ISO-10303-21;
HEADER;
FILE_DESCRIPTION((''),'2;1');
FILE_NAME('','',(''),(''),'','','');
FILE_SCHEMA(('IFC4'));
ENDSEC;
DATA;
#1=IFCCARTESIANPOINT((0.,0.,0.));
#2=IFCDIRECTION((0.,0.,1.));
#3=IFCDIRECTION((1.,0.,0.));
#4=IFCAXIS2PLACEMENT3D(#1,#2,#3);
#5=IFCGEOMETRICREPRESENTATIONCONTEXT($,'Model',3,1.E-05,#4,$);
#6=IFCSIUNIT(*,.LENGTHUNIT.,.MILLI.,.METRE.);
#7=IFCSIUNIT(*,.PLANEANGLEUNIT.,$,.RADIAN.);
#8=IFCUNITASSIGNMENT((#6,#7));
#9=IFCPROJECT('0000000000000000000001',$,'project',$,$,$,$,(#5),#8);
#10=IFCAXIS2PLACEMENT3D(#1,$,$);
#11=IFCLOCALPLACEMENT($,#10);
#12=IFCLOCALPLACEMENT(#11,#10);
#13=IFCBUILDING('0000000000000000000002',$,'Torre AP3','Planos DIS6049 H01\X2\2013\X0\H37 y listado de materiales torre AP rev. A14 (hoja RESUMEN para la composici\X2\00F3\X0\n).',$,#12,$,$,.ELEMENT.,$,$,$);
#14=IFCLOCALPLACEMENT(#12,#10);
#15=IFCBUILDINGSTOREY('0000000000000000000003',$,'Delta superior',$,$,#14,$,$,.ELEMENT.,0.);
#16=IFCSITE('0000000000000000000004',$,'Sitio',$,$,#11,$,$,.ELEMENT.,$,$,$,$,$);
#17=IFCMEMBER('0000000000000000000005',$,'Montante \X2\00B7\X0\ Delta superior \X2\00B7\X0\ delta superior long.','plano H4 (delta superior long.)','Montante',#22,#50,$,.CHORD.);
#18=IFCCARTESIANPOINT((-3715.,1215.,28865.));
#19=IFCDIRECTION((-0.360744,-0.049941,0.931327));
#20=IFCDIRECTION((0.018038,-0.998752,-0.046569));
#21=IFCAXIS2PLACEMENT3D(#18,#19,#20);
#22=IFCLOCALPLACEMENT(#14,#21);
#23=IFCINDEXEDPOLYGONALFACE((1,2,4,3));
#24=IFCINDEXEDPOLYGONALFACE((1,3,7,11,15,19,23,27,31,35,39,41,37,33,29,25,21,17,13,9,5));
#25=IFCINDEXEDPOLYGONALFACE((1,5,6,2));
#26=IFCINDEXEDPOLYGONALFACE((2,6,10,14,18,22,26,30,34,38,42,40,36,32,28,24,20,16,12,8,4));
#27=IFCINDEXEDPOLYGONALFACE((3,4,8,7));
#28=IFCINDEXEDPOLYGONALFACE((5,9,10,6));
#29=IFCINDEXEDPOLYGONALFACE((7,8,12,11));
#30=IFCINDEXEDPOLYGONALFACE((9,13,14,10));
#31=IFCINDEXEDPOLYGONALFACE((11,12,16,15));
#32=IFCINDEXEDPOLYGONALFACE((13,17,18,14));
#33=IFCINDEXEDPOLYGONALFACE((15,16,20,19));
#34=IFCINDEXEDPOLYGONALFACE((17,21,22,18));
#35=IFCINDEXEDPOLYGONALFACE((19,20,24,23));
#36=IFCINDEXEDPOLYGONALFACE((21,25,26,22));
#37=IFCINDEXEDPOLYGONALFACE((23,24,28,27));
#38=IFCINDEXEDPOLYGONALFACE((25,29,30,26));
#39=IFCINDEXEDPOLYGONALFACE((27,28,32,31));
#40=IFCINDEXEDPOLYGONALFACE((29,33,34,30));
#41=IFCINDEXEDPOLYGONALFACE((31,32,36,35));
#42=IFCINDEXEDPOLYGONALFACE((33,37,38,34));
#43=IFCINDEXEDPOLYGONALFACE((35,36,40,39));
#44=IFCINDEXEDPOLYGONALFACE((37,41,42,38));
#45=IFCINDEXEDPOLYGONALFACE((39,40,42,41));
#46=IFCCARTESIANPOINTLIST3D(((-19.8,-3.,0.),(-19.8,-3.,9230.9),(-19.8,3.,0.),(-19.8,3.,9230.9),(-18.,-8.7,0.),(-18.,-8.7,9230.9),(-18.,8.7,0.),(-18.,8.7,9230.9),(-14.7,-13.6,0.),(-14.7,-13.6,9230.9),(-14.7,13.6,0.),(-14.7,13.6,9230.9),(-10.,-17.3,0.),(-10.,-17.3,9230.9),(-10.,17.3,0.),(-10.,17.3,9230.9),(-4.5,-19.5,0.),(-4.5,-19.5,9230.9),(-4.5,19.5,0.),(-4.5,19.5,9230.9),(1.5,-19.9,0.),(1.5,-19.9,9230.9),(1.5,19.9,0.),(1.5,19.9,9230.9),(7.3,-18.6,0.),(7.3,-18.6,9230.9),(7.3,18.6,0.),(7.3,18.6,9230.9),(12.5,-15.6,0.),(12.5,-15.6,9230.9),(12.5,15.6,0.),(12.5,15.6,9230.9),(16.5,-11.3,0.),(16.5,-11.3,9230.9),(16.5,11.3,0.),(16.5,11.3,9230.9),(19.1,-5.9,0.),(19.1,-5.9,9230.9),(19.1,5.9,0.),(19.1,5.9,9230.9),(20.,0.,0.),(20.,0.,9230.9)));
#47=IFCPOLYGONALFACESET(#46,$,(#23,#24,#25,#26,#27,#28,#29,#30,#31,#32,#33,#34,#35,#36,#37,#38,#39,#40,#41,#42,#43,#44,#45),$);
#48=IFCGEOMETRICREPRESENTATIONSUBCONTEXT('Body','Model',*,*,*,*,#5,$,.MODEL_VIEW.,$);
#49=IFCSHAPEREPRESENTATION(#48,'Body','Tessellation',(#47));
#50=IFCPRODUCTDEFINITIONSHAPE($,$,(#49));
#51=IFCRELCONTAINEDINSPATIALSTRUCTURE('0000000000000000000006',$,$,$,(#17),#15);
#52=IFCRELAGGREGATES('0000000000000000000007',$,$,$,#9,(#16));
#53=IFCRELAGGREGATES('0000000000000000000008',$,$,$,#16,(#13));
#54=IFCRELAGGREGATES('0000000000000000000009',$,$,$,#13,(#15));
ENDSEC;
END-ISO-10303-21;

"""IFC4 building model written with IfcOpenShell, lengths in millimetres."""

from ifc_helpers import new_model, si_unit, frame, origin, origin_with_axes, place, context, subcontext, project, spatial, circle, extrude, element, save


model = new_model("IFC4")

# Units and contexts
model_context = context("Model", 3, precision=1e-05, world=origin_with_axes())
body_context = subcontext(model_context, "Body", "Model", "MODEL_VIEW")
ifc_project = project(units=[si_unit("LENGTHUNIT", "METRE", prefix="MILLI"), si_unit("PLANEANGLEUNIT", "RADIAN")], contexts=[model_context])

# Site, building, storey
site_placement = place(None, origin())
site = spatial("IfcSite", under=ifc_project, at=site_placement, Name="Sitio", CompositionType="ELEMENT")
building_placement = place(site_placement, origin())
building = spatial("IfcBuilding", under=site, at=building_placement, Name="Torre AP3", Description="Planos DIS6049 H01–H37 y listado de materiales torre AP rev. A14 (hoja RESUMEN para la composición).", CompositionType="ELEMENT")
storey_placement = place(building_placement, origin())
storey = spatial("IfcBuildingStorey", under=building, at=storey_placement, Name="Delta superior", CompositionType="ELEMENT", Elevation=0.0)

# Member
for number, where, z_axis, x_axis, name in (
    (1, (-3715.0, 1215.0, 28865.0), (-0.360744, -0.049941, 0.931327), (0.018038, -0.998752, -0.046569), "Montante · Delta superior · delta superior long."),
):
    element("IfcMember", number, at=place(storey_placement, frame(where, z_axis=z_axis, x_axis=x_axis)), inside=storey, Name=name, Description="plano H4 (delta superior long.)", ObjectType="Montante", PredefinedType="CHORD", context=body_context, shape_type="SweptSolid", body=[
        extrude(circle(Radius=20.0), None, (0.0, 0.0, 1.0), 9230.9),
    ])

save(model, "model.ifc")
